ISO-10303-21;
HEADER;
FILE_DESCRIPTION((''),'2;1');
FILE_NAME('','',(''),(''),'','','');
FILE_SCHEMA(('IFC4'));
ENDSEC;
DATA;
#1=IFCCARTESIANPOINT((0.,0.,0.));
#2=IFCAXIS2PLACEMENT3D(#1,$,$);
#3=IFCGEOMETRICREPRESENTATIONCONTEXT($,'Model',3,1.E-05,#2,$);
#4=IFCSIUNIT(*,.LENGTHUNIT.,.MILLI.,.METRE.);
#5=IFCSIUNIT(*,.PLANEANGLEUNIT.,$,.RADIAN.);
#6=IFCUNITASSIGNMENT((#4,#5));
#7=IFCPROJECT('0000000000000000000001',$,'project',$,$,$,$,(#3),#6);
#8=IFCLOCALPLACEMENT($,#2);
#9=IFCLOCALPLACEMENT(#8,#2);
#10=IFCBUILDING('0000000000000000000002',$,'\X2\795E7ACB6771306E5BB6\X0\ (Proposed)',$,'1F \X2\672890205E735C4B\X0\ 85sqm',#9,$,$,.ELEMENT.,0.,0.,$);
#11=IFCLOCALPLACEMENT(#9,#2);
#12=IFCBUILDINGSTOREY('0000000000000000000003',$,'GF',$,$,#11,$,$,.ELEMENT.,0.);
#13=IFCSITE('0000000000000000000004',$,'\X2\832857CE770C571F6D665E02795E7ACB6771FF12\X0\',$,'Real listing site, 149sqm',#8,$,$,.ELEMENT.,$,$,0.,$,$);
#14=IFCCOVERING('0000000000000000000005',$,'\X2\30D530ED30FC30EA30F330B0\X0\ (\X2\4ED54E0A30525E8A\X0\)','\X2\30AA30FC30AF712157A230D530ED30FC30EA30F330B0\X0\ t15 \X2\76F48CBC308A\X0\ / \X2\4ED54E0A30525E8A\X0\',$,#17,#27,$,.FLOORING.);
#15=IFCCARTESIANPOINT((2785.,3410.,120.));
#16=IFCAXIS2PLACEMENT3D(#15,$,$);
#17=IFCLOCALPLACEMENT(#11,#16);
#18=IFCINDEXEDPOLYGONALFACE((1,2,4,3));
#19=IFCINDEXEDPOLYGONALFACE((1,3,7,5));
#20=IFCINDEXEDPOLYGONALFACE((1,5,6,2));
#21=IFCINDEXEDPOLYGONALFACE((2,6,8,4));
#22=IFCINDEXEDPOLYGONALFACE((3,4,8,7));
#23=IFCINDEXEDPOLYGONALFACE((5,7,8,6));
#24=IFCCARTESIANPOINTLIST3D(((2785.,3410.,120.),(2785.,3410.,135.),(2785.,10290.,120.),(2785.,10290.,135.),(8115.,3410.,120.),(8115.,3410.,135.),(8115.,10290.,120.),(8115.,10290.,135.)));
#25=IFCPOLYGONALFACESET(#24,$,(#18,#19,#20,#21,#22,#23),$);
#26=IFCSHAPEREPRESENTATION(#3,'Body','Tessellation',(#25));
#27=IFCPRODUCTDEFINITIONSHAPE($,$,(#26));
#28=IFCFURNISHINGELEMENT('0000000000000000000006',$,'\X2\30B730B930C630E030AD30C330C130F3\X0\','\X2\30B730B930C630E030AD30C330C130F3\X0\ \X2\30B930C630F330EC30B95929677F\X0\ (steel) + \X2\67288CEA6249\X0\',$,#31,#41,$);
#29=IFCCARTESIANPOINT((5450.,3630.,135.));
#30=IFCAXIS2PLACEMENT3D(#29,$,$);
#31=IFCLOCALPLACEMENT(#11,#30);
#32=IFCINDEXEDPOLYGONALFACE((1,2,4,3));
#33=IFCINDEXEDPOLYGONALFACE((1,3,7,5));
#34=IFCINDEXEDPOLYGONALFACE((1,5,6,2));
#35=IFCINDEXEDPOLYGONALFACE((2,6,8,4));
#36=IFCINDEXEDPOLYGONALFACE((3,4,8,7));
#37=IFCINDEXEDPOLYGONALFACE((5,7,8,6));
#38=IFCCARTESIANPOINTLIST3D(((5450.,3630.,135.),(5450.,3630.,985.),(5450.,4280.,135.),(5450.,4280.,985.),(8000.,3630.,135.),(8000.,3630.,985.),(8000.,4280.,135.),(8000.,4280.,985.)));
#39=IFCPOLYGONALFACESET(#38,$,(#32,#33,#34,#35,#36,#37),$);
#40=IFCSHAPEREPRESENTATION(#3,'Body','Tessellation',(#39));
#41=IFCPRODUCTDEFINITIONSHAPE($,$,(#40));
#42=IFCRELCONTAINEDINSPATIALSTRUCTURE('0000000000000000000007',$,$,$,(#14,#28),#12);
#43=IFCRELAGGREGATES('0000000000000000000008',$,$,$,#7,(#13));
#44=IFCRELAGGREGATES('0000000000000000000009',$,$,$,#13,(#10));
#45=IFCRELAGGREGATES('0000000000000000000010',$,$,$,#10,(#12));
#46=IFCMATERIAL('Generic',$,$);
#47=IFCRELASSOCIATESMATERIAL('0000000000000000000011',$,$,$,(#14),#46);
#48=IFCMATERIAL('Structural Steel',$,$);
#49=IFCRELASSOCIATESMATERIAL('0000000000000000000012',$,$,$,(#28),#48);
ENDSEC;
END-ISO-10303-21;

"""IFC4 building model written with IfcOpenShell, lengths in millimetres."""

from ifc_helpers import new_model, si_unit, frame, frame_2d, origin, place, context, project, spatial, rectangle, extrude, material, element, save


model = new_model("IFC4")

# Units and contexts
model_context = context("Model", 3, precision=1e-05, world=origin())
ifc_project = project(units=[si_unit("LENGTHUNIT", "METRE", prefix="MILLI"), si_unit("PLANEANGLEUNIT", "RADIAN")], contexts=[model_context])

# Site, building, storey
site_placement = place(None, origin())
site = spatial("IfcSite", under=ifc_project, at=site_placement, Name="茨城県土浦市神立東２", ObjectType="Real listing site, 149sqm", CompositionType="ELEMENT", RefElevation=0.0)
building_placement = place(site_placement, origin())
building = spatial("IfcBuilding", under=site, at=building_placement, Name="神立東の家 (Proposed)", ObjectType="1F 木造平屋 85sqm", CompositionType="ELEMENT", ElevationOfRefHeight=0.0, ElevationOfTerrain=0.0)
storey_placement = place(building_placement, origin())
storey = spatial("IfcBuildingStorey", under=building, at=storey_placement, Name="GF", CompositionType="ELEMENT", Elevation=0.0)

# Shared definitions
ifc_material_1 = material(Name="Generic")

# Covering
covering_placement = place(storey_placement, frame((2785.0, 3410.0, 120.0)))
element("IfcCovering", 1, at=covering_placement, inside=storey, material=ifc_material_1, Name="フローリング (仕上げ床)", Description="オーク無垢フローリング t15 直貼り / 仕上げ床", PredefinedType="FLOORING", context=model_context, shape_type="SweptSolid", body=[
    extrude(rectangle(XDim=5330.0, YDim=6880.0, at=frame_2d((2665.0, 3440.0))), frame((2785.0, 3410.0, 120.0)), (0.0, 0.0, 1.0), 15.0),
])

# Furnishing element
ifc_material_2 = material(Name="Structural Steel")
furnishing_placement = place(storey_placement, frame((5450.0, 3630.0, 135.0)))
element("IfcFurnishingElement", 2, at=furnishing_placement, inside=storey, material=ifc_material_2, Name="システムキッチン", Description="システムキッチン ステンレス天板 (steel) + 木質扉", context=model_context, shape_type="SweptSolid", body=[
    extrude(rectangle(XDim=2550.0, YDim=650.0, at=frame_2d((1275.0, 325.0))), frame((5450.0, 3630.0, 135.0)), (0.0, 0.0, 1.0), 850.0),
])

save(model, "model.ifc")
